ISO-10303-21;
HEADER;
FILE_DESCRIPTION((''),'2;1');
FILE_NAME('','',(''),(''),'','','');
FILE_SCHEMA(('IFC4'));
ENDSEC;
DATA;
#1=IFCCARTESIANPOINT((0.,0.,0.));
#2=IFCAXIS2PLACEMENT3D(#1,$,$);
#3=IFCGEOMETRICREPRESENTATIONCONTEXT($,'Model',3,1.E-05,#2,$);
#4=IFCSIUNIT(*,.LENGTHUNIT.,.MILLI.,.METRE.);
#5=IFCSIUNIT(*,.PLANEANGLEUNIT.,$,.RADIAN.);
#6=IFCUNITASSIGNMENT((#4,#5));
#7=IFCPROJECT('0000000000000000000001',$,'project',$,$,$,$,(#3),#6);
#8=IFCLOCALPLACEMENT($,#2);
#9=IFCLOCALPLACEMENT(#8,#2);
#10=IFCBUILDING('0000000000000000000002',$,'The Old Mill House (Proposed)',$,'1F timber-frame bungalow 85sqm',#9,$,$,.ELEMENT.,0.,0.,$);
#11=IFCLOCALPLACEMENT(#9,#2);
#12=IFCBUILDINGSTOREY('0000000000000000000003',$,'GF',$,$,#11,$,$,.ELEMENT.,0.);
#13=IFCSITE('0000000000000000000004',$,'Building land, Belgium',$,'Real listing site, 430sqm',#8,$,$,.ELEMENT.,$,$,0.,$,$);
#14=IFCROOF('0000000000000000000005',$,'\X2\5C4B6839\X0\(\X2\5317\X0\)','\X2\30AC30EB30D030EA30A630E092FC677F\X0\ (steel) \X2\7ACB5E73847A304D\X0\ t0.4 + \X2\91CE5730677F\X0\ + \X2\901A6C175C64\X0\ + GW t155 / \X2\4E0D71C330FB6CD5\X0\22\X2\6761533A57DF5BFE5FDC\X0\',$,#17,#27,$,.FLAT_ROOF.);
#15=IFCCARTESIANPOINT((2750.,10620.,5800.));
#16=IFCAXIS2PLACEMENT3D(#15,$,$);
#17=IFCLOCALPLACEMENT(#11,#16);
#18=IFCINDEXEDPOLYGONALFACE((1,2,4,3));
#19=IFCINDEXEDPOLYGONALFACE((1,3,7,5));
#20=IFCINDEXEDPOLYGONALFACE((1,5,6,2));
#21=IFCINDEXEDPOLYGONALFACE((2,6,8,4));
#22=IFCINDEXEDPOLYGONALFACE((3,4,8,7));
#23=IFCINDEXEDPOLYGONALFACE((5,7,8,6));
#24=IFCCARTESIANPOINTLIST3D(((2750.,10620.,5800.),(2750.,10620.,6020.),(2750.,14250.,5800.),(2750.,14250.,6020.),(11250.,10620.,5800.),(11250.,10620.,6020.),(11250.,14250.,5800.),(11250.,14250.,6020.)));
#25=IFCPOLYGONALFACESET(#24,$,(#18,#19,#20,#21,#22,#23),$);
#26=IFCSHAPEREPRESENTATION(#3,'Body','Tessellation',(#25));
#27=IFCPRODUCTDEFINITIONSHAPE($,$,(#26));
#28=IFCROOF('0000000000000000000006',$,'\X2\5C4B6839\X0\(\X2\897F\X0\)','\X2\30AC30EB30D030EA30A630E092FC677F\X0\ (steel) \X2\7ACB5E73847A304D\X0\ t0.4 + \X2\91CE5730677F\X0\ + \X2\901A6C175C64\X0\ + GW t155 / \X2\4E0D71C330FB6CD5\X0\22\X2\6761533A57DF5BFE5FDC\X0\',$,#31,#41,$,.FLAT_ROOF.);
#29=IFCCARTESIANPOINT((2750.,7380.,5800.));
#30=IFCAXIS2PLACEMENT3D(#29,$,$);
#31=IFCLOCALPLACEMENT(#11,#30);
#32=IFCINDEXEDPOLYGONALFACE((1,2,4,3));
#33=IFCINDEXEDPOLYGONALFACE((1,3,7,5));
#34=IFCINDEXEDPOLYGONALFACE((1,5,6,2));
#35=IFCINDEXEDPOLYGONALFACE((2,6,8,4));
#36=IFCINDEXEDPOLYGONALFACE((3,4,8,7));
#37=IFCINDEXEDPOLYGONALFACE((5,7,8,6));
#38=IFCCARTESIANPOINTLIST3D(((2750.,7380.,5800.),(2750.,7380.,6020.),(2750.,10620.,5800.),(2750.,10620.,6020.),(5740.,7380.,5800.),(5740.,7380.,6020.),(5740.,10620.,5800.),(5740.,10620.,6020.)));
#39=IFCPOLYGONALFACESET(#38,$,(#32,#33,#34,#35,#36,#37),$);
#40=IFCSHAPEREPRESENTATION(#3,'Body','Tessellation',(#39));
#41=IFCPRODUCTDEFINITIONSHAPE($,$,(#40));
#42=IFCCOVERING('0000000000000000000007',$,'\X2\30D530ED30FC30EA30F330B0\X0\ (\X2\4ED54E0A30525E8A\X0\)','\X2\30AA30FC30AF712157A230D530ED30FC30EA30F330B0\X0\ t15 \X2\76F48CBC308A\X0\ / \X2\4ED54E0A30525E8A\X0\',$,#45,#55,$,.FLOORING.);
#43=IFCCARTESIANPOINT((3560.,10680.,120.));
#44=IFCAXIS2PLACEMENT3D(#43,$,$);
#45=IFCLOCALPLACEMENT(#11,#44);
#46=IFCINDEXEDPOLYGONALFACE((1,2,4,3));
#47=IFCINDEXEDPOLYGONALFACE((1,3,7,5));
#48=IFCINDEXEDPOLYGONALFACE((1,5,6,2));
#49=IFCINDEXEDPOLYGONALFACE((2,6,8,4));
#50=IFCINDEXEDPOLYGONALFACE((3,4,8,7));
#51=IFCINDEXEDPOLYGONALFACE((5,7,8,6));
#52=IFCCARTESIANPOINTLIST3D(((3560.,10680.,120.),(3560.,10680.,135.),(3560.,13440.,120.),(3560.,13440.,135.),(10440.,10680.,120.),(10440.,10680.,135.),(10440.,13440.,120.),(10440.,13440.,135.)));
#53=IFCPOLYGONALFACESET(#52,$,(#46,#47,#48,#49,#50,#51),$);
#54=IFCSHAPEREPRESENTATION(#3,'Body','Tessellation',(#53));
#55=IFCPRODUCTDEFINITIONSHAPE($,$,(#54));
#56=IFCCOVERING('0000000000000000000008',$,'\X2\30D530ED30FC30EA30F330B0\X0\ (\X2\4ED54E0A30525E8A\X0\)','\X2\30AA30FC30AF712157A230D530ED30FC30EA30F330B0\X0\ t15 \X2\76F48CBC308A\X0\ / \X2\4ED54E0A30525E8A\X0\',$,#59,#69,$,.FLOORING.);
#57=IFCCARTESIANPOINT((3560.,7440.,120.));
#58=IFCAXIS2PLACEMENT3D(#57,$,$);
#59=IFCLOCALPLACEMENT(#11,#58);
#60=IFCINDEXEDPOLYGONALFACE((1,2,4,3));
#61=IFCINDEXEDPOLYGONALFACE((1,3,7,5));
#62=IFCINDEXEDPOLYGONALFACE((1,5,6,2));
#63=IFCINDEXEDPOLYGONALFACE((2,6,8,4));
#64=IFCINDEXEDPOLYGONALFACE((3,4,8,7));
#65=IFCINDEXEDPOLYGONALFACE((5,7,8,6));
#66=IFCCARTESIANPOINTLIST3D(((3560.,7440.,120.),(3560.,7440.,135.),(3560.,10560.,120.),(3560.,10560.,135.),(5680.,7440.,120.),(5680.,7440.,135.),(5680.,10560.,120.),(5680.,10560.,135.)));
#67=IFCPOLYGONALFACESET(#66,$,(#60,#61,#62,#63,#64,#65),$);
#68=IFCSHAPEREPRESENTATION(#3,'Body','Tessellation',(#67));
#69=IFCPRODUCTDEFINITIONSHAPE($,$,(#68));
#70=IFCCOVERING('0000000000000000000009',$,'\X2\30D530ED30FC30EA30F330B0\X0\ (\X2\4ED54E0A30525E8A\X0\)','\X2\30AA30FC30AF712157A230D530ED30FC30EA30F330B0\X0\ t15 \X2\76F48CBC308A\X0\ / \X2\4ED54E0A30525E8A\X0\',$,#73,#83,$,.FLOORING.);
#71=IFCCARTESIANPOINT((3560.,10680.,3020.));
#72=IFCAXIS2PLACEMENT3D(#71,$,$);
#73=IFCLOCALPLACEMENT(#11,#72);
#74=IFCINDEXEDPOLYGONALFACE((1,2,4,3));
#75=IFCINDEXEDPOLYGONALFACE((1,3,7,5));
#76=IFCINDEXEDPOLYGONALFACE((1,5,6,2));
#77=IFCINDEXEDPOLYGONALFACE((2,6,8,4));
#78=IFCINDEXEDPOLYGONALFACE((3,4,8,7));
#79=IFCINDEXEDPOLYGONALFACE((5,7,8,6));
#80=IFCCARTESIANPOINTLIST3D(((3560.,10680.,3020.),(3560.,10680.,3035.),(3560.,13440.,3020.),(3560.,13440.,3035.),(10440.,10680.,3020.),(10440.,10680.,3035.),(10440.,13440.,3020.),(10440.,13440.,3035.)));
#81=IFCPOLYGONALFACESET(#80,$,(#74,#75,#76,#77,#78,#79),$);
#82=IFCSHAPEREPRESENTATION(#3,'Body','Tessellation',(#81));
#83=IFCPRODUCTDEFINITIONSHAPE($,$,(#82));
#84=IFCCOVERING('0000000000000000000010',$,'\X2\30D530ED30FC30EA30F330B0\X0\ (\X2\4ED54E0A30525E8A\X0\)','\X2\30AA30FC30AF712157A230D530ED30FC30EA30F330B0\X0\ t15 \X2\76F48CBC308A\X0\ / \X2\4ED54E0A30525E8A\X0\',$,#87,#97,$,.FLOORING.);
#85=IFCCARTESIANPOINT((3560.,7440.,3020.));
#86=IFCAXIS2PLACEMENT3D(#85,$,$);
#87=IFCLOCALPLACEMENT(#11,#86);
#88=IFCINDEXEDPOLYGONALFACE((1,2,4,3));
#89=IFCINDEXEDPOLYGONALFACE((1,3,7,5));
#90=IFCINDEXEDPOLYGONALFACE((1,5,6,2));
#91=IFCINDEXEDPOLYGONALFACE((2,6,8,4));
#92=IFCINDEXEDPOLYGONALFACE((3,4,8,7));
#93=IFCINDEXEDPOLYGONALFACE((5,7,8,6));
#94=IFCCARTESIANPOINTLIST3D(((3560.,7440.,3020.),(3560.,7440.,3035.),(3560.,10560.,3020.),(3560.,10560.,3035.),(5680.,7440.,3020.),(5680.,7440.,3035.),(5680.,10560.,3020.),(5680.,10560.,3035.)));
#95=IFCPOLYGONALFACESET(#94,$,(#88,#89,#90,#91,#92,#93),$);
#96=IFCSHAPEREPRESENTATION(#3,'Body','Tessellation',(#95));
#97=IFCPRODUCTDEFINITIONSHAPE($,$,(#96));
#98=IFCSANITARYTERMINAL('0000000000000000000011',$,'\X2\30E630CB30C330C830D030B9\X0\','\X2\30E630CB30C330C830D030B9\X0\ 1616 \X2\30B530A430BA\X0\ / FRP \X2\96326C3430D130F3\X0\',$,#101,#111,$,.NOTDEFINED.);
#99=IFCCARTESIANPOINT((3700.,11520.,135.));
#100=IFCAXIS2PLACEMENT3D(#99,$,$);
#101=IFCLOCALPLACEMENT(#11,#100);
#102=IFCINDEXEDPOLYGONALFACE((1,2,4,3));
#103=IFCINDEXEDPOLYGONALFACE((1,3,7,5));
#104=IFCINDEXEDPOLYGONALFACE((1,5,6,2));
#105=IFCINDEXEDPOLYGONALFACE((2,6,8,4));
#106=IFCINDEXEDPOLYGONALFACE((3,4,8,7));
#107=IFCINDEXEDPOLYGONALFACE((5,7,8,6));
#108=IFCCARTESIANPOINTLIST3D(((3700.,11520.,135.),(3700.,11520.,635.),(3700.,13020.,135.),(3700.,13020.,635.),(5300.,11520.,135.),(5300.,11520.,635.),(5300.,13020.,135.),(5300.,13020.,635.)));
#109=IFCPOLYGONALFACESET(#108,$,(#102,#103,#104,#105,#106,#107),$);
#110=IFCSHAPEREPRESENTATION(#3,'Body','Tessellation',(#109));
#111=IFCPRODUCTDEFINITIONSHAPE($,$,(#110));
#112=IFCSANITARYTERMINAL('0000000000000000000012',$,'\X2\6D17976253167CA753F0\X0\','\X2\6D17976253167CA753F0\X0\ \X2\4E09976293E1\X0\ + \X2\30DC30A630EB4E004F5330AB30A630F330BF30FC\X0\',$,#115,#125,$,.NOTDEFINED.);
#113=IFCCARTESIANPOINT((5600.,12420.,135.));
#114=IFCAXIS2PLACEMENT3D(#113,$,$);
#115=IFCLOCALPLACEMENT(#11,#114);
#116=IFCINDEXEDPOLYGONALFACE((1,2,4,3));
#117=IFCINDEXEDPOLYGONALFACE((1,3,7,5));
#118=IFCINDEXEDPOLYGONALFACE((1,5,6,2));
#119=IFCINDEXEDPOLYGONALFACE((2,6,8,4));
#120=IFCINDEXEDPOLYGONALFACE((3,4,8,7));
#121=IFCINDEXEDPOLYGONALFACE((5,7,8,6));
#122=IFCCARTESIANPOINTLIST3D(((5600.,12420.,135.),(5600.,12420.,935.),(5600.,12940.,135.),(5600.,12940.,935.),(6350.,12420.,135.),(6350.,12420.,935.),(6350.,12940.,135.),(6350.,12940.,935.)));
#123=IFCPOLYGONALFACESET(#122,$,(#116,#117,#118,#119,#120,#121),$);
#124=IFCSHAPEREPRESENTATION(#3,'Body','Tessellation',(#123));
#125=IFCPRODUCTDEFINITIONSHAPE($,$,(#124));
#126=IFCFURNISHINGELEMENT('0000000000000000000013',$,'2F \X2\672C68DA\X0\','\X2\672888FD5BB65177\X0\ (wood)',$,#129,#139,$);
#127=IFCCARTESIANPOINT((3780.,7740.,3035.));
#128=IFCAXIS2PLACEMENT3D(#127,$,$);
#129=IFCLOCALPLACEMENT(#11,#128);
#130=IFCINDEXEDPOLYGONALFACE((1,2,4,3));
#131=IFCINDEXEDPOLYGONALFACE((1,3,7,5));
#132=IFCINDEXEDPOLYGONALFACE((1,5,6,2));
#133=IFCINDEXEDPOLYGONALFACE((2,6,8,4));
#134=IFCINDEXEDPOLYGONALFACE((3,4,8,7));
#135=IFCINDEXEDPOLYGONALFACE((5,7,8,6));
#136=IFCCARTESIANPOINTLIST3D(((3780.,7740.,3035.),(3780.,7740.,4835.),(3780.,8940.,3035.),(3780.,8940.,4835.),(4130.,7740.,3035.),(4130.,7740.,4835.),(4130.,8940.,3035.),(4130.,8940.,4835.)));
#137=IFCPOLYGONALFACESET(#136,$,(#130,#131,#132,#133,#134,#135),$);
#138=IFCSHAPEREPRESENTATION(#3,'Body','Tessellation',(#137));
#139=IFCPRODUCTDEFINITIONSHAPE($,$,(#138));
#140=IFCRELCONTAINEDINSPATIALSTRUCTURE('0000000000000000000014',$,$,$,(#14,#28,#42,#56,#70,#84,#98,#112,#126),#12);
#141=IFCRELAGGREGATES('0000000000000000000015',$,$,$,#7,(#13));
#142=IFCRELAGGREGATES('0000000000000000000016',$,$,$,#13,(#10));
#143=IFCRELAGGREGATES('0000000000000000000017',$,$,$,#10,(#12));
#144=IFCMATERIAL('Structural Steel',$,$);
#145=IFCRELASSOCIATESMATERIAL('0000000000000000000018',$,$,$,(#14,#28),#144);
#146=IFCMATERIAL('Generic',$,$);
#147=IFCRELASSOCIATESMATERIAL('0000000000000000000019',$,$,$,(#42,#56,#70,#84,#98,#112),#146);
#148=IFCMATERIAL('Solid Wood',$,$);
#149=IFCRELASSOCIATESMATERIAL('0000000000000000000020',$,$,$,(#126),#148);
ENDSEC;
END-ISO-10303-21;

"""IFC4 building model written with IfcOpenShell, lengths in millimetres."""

from ifc_helpers import new_model, si_unit, frame, frame_2d, origin, place, context, project, spatial, rectangle, extrude, material, element, save


model = new_model("IFC4")

# Units and contexts
model_context = context("Model", 3, precision=1e-05, world=origin())
ifc_project = project(units=[si_unit("LENGTHUNIT", "METRE", prefix="MILLI"), si_unit("PLANEANGLEUNIT", "RADIAN")], contexts=[model_context])

# Site, building, storey
site_placement = place(None, origin())
site = spatial("IfcSite", under=ifc_project, at=site_placement, Name="Building land, Belgium", ObjectType="Real listing site, 430sqm", CompositionType="ELEMENT", RefElevation=0.0)
building_placement = place(site_placement, origin())
building = spatial("IfcBuilding", under=site, at=building_placement, Name="The Old Mill House (Proposed)", ObjectType="1F timber-frame bungalow 85sqm", CompositionType="ELEMENT", ElevationOfRefHeight=0.0, ElevationOfTerrain=0.0)
storey_placement = place(building_placement, origin())
storey = spatial("IfcBuildingStorey", under=building, at=storey_placement, Name="GF", CompositionType="ELEMENT", Elevation=0.0)

# Shared definitions
ifc_material_1 = material(Name="Solid Wood")

# Roofs
ifc_material_2 = material(Name="Structural Steel")
for number, where, name in (
    (1, (2750.0, 10620.0, 5800.0), "屋根(北)"),
):
    element("IfcRoof", number, at=place(storey_placement, frame(where)), inside=storey, material=ifc_material_2, Name=name, Description="ガルバリウム鋼板 (steel) 立平葺き t0.4 + 野地板 + 通気層 + GW t155 / 不燃・法22条区域対応", PredefinedType="FLAT_ROOF", context=model_context, shape_type="SweptSolid", body=[
        extrude(rectangle(XDim=8500.0, YDim=3630.0, at=frame_2d((4250.0, 1815.0))), frame((2750.0, 10620.0, 5800.0)), (0.0, 0.0, 1.0), 220.0),
    ])
roof_placement = place(storey_placement, frame((2750.0, 7380.0, 5800.0)))
element("IfcRoof", 2, at=roof_placement, inside=storey, material=ifc_material_2, Name="屋根(西)", Description="ガルバリウム鋼板 (steel) 立平葺き t0.4 + 野地板 + 通気層 + GW t155 / 不燃・法22条区域対応", PredefinedType="FLAT_ROOF", context=model_context, shape_type="SweptSolid", body=[
    extrude(rectangle(XDim=2990.0, YDim=3240.0, at=frame_2d((1495.0, 1620.0))), frame((2750.0, 7380.0, 5800.0)), (0.0, 0.0, 1.0), 220.0),
])

# Coverings
ifc_material_3 = material(Name="Generic")
covering_1_placement = place(storey_placement, frame((3560.0, 10680.0, 120.0)))
element("IfcCovering", 3, at=covering_1_placement, inside=storey, material=ifc_material_3, Name="フローリング (仕上げ床)", Description="オーク無垢フローリング t15 直貼り / 仕上げ床", PredefinedType="FLOORING", context=model_context, shape_type="SweptSolid", body=[
    extrude(rectangle(XDim=6880.0, YDim=2760.0, at=frame_2d((3440.0, 1380.0))), frame((3560.0, 10680.0, 120.0)), (0.0, 0.0, 1.0), 15.0),
])
covering_2_placement = place(storey_placement, frame((3560.0, 7440.0, 120.0)))
element("IfcCovering", 4, at=covering_2_placement, inside=storey, material=ifc_material_3, Name="フローリング (仕上げ床)", Description="オーク無垢フローリング t15 直貼り / 仕上げ床", PredefinedType="FLOORING", context=model_context, shape_type="SweptSolid", body=[
    extrude(rectangle(XDim=2120.0, YDim=3120.0, at=frame_2d((1060.0, 1560.0))), frame((3560.0, 7440.0, 120.0)), (0.0, 0.0, 1.0), 15.0),
])
covering_3_placement = place(storey_placement, frame((3560.0, 10680.0, 3020.0)))
element("IfcCovering", 5, at=covering_3_placement, inside=storey, material=ifc_material_3, Name="フローリング (仕上げ床)", Description="オーク無垢フローリング t15 直貼り / 仕上げ床", PredefinedType="FLOORING", context=model_context, shape_type="SweptSolid", body=[
    extrude(rectangle(XDim=6880.0, YDim=2760.0, at=frame_2d((3440.0, 1380.0))), frame((3560.0, 10680.0, 3020.0)), (0.0, 0.0, 1.0), 15.0),
])
covering_4_placement = place(storey_placement, frame((3560.0, 7440.0, 3020.0)))
element("IfcCovering", 6, at=covering_4_placement, inside=storey, material=ifc_material_3, Name="フローリング (仕上げ床)", Description="オーク無垢フローリング t15 直貼り / 仕上げ床", PredefinedType="FLOORING", context=model_context, shape_type="SweptSolid", body=[
    extrude(rectangle(XDim=2120.0, YDim=3120.0, at=frame_2d((1060.0, 1560.0))), frame((3560.0, 7440.0, 3020.0)), (0.0, 0.0, 1.0), 15.0),
])

# Sanitary terminals
sanitary_terminal_1_placement = place(storey_placement, frame((3700.0, 11520.0, 135.0)))
element("IfcSanitaryTerminal", 7, at=sanitary_terminal_1_placement, inside=storey, material=ifc_material_3, Name="ユニットバス", Description="ユニットバス 1616 サイズ / FRP 防水パン", PredefinedType="NOTDEFINED", context=model_context, shape_type="SweptSolid", body=[
    extrude(rectangle(XDim=1600.0, YDim=1500.0, at=frame_2d((800.0, 750.0))), frame((3700.0, 11520.0, 135.0)), (0.0, 0.0, 1.0), 500.0),
])
sanitary_terminal_2_placement = place(storey_placement, frame((5600.0, 12420.0, 135.0)))
element("IfcSanitaryTerminal", 8, at=sanitary_terminal_2_placement, inside=storey, material=ifc_material_3, Name="洗面化粧台", Description="洗面化粧台 三面鏡 + ボウル一体カウンター", PredefinedType="NOTDEFINED", context=model_context, shape_type="SweptSolid", body=[
    extrude(rectangle(XDim=750.0, YDim=520.0, at=frame_2d((375.0, 260.0))), frame((5600.0, 12420.0, 135.0)), (0.0, 0.0, 1.0), 800.0),
])

# Furnishing element
furnishing_placement = place(storey_placement, frame((3780.0, 7740.0, 3035.0)))
element("IfcFurnishingElement", 9, at=furnishing_placement, inside=storey, material=ifc_material_1, Name="2F 本棚", Description="木製家具 (wood)", context=model_context, shape_type="SweptSolid", body=[
    extrude(rectangle(XDim=350.0, YDim=1200.0, at=frame_2d((175.0, 600.0))), frame((3780.0, 7740.0, 3035.0)), (0.0, 0.0, 1.0), 1800.0),
])

save(model, "model.ifc")
